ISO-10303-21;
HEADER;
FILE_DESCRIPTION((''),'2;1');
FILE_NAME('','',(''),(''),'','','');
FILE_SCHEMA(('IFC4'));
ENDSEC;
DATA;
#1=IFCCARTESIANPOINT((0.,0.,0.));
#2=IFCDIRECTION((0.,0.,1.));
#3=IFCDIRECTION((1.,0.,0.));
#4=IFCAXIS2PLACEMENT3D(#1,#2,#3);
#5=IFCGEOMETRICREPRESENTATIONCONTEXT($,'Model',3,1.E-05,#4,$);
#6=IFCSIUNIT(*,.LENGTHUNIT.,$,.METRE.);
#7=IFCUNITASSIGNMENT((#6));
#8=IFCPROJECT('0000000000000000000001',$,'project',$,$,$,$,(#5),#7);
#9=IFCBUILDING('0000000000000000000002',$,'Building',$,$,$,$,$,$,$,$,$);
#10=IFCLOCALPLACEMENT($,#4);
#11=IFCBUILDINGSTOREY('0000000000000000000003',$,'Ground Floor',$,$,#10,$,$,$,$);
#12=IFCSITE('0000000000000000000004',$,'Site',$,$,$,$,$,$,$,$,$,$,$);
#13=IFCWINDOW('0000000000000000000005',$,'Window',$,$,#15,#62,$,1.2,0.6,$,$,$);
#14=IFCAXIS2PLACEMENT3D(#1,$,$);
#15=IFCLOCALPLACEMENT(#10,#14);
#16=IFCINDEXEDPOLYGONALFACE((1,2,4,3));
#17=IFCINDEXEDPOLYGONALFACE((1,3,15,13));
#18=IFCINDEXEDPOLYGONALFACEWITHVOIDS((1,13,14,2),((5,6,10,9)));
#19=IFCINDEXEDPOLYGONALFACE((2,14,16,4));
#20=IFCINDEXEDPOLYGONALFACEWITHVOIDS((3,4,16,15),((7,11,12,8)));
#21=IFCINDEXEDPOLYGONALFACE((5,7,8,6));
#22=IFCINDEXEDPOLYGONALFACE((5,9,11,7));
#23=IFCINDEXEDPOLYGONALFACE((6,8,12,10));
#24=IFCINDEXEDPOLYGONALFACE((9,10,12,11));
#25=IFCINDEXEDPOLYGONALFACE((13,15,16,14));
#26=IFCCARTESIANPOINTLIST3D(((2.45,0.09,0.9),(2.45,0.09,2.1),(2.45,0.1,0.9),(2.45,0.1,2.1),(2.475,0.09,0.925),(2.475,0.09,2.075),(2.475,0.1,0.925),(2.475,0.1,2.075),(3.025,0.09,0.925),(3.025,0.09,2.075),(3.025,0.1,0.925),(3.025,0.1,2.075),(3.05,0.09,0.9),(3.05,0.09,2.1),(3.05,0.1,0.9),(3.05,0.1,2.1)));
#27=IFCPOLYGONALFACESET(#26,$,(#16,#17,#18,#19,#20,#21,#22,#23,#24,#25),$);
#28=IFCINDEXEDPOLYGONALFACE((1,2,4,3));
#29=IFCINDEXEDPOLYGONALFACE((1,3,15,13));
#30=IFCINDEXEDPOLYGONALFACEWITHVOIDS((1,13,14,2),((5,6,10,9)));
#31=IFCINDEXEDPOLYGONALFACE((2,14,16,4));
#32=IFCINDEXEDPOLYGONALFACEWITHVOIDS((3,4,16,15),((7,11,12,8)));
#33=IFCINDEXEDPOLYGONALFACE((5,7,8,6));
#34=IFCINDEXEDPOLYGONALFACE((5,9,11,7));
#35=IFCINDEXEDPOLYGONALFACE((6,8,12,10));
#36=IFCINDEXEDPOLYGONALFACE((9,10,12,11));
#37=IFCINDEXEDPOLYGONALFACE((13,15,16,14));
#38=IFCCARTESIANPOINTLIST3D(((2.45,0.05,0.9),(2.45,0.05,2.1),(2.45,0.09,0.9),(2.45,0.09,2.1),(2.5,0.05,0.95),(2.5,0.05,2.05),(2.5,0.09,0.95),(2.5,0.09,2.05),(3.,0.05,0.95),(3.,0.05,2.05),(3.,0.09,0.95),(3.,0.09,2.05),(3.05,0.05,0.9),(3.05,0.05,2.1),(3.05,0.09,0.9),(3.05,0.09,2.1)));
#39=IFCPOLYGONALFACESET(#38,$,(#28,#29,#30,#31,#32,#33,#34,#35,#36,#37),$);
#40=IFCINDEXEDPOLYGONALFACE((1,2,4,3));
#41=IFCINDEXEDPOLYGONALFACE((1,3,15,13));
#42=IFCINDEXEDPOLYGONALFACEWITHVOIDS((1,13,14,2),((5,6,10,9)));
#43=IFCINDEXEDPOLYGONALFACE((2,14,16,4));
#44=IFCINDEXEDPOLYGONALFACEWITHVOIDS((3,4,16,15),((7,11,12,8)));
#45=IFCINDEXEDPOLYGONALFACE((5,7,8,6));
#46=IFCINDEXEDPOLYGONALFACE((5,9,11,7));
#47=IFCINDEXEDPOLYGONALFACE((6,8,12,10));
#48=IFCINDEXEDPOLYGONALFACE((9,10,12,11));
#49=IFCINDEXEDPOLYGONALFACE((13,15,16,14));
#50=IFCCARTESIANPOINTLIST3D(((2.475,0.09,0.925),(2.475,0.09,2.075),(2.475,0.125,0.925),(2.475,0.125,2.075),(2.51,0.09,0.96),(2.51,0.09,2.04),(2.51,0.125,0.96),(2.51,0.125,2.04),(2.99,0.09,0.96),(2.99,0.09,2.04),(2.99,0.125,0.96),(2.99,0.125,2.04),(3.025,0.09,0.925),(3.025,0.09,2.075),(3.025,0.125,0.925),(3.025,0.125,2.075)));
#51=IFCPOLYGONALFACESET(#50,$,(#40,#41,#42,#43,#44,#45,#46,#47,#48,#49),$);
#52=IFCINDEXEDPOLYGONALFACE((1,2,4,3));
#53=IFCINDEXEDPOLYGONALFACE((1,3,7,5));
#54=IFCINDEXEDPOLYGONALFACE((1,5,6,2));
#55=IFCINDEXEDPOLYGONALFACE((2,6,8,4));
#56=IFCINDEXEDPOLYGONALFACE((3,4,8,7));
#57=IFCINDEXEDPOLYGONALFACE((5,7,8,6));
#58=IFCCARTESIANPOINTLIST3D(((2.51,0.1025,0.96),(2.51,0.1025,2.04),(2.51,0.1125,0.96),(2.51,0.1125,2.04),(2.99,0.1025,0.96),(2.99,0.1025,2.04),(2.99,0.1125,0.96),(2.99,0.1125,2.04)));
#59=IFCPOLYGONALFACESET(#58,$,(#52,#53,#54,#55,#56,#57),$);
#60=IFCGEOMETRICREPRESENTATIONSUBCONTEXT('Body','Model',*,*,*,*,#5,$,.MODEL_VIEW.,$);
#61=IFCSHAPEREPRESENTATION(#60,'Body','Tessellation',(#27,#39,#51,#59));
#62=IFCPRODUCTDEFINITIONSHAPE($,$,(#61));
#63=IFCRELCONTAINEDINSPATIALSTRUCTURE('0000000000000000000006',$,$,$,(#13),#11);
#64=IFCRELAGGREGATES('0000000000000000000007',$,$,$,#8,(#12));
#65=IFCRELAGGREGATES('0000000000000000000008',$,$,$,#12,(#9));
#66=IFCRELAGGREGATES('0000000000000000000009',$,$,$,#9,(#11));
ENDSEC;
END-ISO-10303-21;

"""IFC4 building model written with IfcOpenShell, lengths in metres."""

from ifc_helpers import new_model, si_unit, frame, origin_with_axes, place, context, subcontext, project, spatial, line, indexed_curve, outline, extrude, element, save


model = new_model("IFC4")

# Units and contexts
model_context = context("Model", 3, precision=1e-05, world=origin_with_axes())
body_context = subcontext(model_context, "Body", "Model", "MODEL_VIEW")
ifc_project = project(units=[si_unit("LENGTHUNIT", "METRE")], contexts=[model_context])

# Site, building, storey
site = spatial("IfcSite", under=ifc_project, Name="Site")
building = spatial("IfcBuilding", under=site, Name="Building")
storey_placement = place(None, origin_with_axes())
storey = spatial("IfcBuildingStorey", under=building, at=storey_placement, Name="Ground Floor")

# Window
window_1_placement = place(storey_placement, frame((2.45, 0.0, 0.9), z_axis=(0.0, 0.0, 1.0), x_axis=(1.0, 0.0, 0.0)))
element("IfcWindow", 1, at=window_1_placement, inside=storey, Name="Window", OverallHeight=1.2, OverallWidth=0.6, context=body_context, shape_type="SweptSolid", body=[
    extrude(outline(indexed_curve([(0.0, 0.0), (0.6, 0.0), (0.6, 1.2), (0.0, 1.2)], segments=[line(1, 2, 3, 4, 1)]), holes=[indexed_curve([(0.025, 0.025), (0.575, 0.025), (0.575, 1.175), (0.025, 1.175)], segments=[line(1, 2, 3, 4, 1)])]), frame((0.0, 0.09, 0.0), z_axis=(0.0, -1.0, 0.0), x_axis=(1.0, 0.0, 0.0)), (0.0, 0.0, -1.0), 0.01),
    extrude(outline(indexed_curve([(0.0, 0.0), (0.6, 0.0), (0.6, 1.2), (0.0, 1.2)], segments=[line(1, 2, 3, 4, 1)]), holes=[indexed_curve([(0.05, 0.05), (0.55, 0.05), (0.55, 1.15), (0.05, 1.15)], segments=[line(1, 2, 3, 4, 1)])]), frame((0.0, 0.05, 0.0), z_axis=(0.0, -1.0, 0.0), x_axis=(1.0, 0.0, 0.0)), (0.0, 0.0, -1.0), 0.04),
    extrude(outline(indexed_curve([(0.0, 0.0), (0.55, 0.0), (0.55, 1.15), (0.0, 1.15)], segments=[line(1, 2, 3, 4, 1)]), holes=[indexed_curve([(0.035, 0.035), (0.515, 0.035), (0.515, 1.115), (0.035, 1.115)], segments=[line(1, 2, 3, 4, 1)])]), frame((0.025, 0.09, 0.025), z_axis=(0.0, -1.0, 0.0), x_axis=(1.0, 0.0, 0.0)), (0.0, 0.0, -1.0), 0.035),
    extrude(outline(indexed_curve([(0.035, 0.035), (0.515, 0.035), (0.515, 1.115), (0.035, 1.115)], segments=[line(1, 2, 3, 4, 1)])), frame((0.025, 0.1025, 0.025), z_axis=(0.0, -1.0, 0.0), x_axis=(1.0, 0.0, 0.0)), (0.0, 0.0, -1.0), 0.01),
])

save(model, "model.ifc")
